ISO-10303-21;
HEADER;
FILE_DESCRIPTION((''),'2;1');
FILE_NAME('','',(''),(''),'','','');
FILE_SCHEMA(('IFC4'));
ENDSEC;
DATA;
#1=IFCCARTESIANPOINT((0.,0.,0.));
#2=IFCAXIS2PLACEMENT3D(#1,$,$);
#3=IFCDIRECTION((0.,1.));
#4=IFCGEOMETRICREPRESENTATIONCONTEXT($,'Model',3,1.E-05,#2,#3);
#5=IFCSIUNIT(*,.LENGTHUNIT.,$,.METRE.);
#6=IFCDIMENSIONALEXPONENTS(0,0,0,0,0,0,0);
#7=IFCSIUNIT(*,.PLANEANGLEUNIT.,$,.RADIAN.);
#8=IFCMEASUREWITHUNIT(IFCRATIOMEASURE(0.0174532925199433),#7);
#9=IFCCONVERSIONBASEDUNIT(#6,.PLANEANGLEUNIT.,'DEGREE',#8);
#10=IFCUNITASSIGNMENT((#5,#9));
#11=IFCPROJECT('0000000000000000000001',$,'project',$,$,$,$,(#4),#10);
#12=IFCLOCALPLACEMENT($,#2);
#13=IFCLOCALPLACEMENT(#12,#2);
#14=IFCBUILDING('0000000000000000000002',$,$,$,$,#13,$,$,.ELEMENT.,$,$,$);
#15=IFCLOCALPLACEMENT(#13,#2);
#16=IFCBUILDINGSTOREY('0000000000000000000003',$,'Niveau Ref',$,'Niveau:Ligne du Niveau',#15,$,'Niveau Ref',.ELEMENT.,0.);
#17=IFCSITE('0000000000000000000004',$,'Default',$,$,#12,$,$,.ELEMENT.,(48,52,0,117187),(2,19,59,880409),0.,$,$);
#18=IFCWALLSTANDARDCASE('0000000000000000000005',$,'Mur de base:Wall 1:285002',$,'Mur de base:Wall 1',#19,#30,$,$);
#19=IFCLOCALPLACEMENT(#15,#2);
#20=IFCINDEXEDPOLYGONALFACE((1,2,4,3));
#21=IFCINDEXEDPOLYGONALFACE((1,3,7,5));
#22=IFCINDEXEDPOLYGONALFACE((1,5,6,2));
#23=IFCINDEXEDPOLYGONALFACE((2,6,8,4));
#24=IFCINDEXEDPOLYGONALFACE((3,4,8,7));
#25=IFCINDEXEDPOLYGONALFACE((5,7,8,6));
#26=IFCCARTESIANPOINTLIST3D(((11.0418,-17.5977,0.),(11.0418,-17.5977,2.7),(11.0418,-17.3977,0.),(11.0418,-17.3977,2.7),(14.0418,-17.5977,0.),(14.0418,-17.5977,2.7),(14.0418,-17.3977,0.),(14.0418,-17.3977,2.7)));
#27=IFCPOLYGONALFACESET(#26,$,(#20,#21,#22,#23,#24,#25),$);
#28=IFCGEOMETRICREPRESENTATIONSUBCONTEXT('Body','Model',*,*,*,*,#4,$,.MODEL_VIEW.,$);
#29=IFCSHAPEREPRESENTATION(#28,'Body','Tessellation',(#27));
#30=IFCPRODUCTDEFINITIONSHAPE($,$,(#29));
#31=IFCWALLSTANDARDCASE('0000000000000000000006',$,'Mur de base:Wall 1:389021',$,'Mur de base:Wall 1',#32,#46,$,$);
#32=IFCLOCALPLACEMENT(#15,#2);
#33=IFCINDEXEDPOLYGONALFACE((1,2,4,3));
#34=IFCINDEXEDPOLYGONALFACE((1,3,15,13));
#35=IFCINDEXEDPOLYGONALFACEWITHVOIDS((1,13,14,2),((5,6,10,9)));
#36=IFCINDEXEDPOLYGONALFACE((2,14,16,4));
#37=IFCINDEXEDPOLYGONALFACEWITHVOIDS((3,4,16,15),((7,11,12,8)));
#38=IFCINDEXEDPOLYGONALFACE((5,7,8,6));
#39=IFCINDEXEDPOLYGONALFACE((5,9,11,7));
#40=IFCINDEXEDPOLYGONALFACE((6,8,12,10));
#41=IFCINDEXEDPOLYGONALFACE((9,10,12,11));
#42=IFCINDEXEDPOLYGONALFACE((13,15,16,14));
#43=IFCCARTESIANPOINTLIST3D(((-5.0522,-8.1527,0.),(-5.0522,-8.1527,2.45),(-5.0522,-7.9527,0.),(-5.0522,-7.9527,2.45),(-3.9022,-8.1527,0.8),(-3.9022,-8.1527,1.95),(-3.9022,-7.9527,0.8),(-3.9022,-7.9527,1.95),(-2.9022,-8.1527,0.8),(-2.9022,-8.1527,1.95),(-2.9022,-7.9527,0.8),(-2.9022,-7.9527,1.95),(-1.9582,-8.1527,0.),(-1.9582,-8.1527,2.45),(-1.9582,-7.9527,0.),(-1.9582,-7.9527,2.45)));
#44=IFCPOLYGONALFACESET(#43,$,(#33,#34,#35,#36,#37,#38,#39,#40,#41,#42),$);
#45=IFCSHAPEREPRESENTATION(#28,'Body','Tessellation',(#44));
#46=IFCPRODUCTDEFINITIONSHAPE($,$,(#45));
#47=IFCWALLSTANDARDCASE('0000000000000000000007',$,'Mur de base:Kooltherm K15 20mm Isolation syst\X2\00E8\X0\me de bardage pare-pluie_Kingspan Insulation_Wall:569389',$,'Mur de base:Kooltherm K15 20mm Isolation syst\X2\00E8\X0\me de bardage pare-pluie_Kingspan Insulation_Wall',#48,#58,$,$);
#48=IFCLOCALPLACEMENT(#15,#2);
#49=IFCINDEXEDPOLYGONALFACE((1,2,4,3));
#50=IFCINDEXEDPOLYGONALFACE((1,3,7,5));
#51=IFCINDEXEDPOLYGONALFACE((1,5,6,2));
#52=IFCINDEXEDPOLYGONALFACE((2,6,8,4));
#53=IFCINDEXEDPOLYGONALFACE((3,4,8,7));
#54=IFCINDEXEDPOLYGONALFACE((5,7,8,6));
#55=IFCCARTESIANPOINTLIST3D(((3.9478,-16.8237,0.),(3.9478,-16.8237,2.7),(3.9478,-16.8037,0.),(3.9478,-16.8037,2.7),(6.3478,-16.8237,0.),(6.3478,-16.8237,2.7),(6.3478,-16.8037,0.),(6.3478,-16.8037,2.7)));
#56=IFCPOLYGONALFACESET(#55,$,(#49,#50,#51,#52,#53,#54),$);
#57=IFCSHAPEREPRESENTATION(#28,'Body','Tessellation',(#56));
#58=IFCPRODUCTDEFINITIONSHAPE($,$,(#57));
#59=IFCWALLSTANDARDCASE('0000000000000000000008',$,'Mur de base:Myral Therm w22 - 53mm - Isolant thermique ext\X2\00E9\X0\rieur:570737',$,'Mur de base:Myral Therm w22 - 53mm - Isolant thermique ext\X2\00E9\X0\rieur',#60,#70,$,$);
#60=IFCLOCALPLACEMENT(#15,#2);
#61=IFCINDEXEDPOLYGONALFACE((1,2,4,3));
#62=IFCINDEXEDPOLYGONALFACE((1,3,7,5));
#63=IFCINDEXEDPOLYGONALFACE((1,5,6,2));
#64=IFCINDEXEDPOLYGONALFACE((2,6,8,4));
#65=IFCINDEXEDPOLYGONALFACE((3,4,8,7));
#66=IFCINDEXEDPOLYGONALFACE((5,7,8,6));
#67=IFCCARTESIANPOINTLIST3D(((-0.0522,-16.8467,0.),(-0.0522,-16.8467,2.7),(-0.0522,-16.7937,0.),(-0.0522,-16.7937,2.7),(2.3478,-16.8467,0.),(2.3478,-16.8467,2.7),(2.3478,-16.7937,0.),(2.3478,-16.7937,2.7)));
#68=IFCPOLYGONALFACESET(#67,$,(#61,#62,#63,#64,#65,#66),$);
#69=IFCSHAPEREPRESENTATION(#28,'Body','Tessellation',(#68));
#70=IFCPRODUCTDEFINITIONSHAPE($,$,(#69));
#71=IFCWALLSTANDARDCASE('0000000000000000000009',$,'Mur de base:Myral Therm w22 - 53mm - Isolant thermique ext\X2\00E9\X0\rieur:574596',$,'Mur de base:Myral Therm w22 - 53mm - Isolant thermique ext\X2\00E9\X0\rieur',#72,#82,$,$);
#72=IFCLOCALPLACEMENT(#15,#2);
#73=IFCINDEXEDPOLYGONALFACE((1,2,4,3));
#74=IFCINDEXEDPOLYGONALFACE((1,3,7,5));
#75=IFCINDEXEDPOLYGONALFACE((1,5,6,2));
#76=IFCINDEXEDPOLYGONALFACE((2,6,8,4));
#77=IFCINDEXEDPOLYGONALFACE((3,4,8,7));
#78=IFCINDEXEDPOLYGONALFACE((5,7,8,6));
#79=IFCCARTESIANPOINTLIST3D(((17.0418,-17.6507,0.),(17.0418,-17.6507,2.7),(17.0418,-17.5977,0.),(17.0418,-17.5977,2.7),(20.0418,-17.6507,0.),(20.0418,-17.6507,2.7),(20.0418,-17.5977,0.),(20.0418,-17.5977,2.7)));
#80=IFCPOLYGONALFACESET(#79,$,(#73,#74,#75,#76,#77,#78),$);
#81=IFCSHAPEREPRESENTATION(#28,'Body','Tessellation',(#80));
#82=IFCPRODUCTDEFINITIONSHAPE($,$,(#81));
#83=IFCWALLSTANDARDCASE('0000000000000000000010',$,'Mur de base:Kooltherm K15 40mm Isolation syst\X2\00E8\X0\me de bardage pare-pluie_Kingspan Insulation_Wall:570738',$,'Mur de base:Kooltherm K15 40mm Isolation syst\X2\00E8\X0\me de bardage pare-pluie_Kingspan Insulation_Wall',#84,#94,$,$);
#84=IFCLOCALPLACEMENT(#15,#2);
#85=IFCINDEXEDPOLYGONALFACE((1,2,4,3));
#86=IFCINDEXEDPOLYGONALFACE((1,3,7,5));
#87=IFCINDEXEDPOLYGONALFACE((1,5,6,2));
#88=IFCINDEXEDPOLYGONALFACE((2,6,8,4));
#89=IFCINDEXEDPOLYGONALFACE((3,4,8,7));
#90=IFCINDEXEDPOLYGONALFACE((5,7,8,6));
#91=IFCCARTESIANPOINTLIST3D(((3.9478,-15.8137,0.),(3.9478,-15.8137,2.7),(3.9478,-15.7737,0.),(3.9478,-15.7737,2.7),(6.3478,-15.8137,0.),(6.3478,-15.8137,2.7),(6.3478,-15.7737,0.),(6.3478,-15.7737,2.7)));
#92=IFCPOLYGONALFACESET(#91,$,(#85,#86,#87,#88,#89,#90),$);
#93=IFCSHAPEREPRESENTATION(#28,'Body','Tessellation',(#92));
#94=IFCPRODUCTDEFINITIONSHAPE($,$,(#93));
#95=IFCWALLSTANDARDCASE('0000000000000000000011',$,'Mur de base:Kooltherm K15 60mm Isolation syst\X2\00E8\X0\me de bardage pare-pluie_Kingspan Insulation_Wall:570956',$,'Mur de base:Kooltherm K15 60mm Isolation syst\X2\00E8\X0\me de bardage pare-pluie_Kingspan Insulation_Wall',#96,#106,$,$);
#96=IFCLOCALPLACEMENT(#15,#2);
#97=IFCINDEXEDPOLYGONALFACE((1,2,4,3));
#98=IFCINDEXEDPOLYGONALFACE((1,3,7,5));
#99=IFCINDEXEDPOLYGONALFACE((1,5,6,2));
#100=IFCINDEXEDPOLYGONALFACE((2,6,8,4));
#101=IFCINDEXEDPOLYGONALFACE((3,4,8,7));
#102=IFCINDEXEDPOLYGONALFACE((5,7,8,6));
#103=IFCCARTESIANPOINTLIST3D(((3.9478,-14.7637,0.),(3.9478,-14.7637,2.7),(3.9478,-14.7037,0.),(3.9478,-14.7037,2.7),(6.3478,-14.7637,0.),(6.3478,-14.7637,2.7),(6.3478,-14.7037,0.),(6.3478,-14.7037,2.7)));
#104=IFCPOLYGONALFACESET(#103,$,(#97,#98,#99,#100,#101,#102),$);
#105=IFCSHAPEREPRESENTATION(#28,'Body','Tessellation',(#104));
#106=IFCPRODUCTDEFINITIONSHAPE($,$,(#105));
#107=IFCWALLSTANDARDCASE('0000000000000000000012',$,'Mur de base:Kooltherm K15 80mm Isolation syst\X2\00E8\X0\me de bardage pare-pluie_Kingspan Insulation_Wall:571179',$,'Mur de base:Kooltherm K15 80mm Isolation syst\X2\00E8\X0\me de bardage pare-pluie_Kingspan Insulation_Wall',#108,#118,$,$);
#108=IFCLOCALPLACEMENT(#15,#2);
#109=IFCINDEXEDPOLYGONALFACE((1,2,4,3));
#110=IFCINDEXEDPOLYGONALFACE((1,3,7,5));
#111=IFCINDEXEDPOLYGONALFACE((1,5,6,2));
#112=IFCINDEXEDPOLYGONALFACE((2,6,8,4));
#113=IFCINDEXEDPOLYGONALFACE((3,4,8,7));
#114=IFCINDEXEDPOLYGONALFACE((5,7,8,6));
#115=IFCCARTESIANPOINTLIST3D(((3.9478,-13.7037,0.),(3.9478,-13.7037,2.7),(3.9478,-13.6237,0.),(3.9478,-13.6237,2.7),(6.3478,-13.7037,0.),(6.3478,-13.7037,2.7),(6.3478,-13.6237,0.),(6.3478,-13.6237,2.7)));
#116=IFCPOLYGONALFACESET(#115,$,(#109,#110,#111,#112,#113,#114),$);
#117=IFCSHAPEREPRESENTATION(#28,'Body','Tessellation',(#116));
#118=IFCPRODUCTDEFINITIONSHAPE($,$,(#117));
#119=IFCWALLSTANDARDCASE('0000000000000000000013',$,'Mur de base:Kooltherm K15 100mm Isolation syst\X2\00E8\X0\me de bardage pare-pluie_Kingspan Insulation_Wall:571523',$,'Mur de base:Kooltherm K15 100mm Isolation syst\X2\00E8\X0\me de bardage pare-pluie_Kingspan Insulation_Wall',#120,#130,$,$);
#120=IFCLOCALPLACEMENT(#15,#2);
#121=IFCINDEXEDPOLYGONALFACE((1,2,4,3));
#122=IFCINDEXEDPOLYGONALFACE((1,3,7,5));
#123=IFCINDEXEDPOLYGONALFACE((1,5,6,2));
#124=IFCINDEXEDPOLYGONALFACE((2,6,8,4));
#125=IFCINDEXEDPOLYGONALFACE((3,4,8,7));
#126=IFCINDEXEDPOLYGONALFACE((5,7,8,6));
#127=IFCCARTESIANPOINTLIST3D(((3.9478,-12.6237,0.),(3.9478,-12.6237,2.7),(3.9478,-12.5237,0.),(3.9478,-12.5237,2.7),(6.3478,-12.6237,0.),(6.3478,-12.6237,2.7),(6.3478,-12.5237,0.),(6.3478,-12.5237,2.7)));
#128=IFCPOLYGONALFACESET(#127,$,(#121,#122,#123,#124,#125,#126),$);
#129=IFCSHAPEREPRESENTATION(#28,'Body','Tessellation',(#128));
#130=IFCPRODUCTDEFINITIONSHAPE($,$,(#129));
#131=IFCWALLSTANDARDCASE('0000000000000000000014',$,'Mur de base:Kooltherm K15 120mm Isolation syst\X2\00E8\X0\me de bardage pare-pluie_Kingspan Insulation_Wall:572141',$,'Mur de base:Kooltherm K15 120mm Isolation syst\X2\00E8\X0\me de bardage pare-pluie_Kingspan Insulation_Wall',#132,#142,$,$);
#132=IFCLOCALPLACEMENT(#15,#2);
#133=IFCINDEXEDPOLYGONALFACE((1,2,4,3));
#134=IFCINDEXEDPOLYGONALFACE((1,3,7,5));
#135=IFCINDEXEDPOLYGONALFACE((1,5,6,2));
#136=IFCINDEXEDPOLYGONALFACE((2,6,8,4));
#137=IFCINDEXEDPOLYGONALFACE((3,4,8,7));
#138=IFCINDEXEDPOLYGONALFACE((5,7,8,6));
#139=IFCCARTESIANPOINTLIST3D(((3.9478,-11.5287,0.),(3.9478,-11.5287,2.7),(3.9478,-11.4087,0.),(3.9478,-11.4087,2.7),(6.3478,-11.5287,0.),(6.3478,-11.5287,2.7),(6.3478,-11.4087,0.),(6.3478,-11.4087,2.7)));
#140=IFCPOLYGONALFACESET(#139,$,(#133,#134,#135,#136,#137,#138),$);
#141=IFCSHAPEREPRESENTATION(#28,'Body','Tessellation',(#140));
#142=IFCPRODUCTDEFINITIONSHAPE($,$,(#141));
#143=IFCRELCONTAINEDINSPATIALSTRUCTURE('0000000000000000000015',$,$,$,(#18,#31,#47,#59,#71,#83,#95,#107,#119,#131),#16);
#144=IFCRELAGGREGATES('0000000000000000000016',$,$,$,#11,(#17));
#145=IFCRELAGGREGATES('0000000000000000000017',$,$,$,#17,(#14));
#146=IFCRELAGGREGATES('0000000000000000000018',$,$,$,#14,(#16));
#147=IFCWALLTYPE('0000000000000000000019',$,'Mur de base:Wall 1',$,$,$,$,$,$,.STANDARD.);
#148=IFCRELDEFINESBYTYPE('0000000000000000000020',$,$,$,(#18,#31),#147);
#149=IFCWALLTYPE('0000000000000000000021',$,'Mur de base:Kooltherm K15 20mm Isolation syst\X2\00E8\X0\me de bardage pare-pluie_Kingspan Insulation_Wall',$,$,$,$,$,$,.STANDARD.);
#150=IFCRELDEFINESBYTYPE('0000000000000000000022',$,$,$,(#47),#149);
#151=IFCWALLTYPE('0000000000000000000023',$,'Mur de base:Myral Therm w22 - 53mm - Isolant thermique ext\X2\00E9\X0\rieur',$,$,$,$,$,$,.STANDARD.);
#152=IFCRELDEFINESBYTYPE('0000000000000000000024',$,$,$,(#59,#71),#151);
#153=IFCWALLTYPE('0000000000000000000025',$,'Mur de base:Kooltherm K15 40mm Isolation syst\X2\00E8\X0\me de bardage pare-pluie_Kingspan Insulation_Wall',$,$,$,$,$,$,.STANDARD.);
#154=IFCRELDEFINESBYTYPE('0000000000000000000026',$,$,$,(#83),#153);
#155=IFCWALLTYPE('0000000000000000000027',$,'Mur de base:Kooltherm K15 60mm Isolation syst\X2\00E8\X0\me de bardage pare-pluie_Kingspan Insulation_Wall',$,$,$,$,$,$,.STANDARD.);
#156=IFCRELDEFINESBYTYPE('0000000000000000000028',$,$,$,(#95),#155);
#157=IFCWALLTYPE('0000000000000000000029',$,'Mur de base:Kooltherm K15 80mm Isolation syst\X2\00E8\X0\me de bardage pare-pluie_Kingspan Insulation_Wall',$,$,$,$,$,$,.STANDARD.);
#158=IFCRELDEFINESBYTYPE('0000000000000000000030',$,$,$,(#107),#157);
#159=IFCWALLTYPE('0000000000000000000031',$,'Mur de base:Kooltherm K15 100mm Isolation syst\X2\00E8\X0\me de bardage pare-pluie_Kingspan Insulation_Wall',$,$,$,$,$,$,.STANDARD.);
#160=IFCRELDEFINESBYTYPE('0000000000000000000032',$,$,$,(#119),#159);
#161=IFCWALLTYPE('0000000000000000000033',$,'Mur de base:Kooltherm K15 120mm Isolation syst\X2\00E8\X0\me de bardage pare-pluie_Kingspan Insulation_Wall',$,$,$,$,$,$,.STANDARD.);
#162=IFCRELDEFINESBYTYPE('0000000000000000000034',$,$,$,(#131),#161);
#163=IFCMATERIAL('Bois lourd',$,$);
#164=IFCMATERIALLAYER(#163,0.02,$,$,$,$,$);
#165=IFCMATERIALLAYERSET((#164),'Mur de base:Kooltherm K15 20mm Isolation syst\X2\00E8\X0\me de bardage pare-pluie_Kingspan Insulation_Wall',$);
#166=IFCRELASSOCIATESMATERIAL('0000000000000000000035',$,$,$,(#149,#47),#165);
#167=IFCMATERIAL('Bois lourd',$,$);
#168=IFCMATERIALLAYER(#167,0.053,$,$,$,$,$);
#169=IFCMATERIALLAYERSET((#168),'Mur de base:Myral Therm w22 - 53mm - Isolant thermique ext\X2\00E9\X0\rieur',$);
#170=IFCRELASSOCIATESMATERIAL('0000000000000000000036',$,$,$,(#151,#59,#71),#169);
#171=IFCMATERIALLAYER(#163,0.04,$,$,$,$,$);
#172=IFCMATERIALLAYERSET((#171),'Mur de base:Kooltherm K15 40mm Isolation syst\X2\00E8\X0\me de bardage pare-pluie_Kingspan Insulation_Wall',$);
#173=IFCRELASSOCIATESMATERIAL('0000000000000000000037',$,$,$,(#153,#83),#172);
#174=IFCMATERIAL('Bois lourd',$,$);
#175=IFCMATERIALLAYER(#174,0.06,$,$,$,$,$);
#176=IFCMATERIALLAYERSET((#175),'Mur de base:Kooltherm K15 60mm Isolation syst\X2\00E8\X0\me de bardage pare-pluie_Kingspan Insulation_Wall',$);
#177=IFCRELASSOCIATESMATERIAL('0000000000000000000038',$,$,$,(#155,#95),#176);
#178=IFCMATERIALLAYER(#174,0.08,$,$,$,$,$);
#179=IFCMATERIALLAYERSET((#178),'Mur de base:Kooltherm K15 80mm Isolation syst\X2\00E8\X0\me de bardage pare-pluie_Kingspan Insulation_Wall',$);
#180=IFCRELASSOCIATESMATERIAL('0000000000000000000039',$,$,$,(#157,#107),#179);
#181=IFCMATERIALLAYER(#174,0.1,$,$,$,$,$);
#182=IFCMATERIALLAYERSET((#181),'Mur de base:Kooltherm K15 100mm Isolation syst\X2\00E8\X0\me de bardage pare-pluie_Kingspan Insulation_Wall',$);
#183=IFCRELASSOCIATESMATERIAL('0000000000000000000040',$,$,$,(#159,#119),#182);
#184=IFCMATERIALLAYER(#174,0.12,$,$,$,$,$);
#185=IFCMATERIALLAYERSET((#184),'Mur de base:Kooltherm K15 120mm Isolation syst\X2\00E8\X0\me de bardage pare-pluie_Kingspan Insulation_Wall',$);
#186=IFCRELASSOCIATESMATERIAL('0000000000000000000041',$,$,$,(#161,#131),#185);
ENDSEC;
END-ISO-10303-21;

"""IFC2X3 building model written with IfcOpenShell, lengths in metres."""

from ifc_helpers import new_model, entity, si_unit, converted_unit, direction, frame, frame_2d, origin, place, context, subcontext, project, spatial, rectangle, extrude, material, layer, layer_set, layer_usage, type_object, element, save


model = new_model("IFC2X3")

# Units and contexts
model_context = context("Model", 3, precision=1e-05, world=origin(), true_north=direction((0.0, 1.0)))
body_context = subcontext(model_context, "Body", "Model", "MODEL_VIEW")
ifc_project = project(units=[si_unit("LENGTHUNIT", "METRE"), converted_unit("PLANEANGLEUNIT", "DEGREE", entity("IfcRatioMeasure", 0.0174532925199433), si_unit("PLANEANGLEUNIT", "RADIAN"), dimensions=[0, 0, 0, 0, 0, 0, 0])], contexts=[model_context])

# Site, building, storey
site_placement = place(None, origin())
site = spatial("IfcSite", under=ifc_project, at=site_placement, Name="Default", CompositionType="ELEMENT", RefLatitude=(48, 52, 0, 117187), RefLongitude=(2, 19, 59, 880409), RefElevation=0.0)
building_placement = place(site_placement, origin())
building = spatial("IfcBuilding", under=site, at=building_placement, CompositionType="ELEMENT")
storey_placement = place(building_placement, origin())
storey = spatial("IfcBuildingStorey", under=building, at=storey_placement, Name="Niveau Ref", ObjectType="Niveau:Ligne du Niveau", LongName="Niveau Ref", CompositionType="ELEMENT", Elevation=0.0)

# Wall
wall_type_1 = type_object("IfcWallType", Name="Mur de base:Wall 1", PredefinedType="STANDARD")
for number, where, name in (
    (1, (11.0418, -17.4977, 0.0), "Mur de base:Wall 1:285002"),
):
    element("IfcWallStandardCase", number, at=place(storey_placement, frame(where)), inside=storey, type_object=wall_type_1, Name=name, ObjectType="Mur de base:Wall 1", context=body_context, shape_type="SweptSolid", body=[
        extrude(rectangle(XDim=3.0, YDim=0.2, at=frame_2d((1.5, 0.0), x_axis=(-1.0, 0.0))), origin(), (0.0, 0.0, 1.0), 2.7),
    ])

# Wall, opening
wall_1_placement = place(storey_placement, frame((-1.9582, -8.0527, 0.0), z_axis=(0.0, 0.0, 1.0), x_axis=(-1.0, 0.0, 0.0)))
wall_1 = element("IfcWallStandardCase", 2, at=wall_1_placement, inside=storey, type_object=wall_type_1, Name="Mur de base:Wall 1:389021", ObjectType="Mur de base:Wall 1", context=body_context, shape_type="SweptSolid", body=[
    extrude(rectangle(XDim=3.094, YDim=0.2, at=frame_2d((1.547, 0.0), x_axis=(-1.0, 0.0))), origin(), (0.0, 0.0, 1.0), 2.45),
])
opening_placement = place(wall_1_placement, frame((0.944, -0.1, 0.8)))
element("IfcOpeningElement", 3, at=opening_placement, cuts=wall_1, ObjectType="Opening", context=body_context, shape_type="SweptSolid", body=[
    extrude(rectangle(XDim=1.15, YDim=1.0, at=frame_2d((0.575, 0.5), x_axis=(1.0, 0.0))), frame((0.0, 0.0, 0.0), z_axis=(0.0, 1.0, 0.0), x_axis=(0.0, 0.0, 1.0)), (0.0, 0.0, 1.0), 0.2),
])

# Walls
ifc_material_1 = material(Name="Bois lourd")
ifc_layer_1 = layer(ifc_material_1, 0.02)
ifc_layer_set_1 = layer_set([ifc_layer_1], Name="Mur de base:Kooltherm K15 20mm Isolation système de bardage pare-pluie_Kingspan Insulation_Wall")
ifc_layer_usage_1 = layer_usage(ifc_layer_set_1, "AXIS2", "NEGATIVE", 0.01)
wall_type_2 = type_object("IfcWallType", Name="Mur de base:Kooltherm K15 20mm Isolation système de bardage pare-pluie_Kingspan Insulation_Wall", PredefinedType="STANDARD", material=ifc_layer_set_1)
wall_2_placement = place(storey_placement, frame((3.9478, -16.8137, 0.0)))
element("IfcWallStandardCase", 4, at=wall_2_placement, inside=storey, type_object=wall_type_2, material=ifc_layer_usage_1, Name="Mur de base:Kooltherm K15 20mm Isolation système de bardage pare-pluie_Kingspan Insulation_Wall:569389", ObjectType="Mur de base:Kooltherm K15 20mm Isolation système de bardage pare-pluie_Kingspan Insulation_Wall", context=body_context, shape_type="SweptSolid", body=[
    extrude(rectangle(XDim=2.4, YDim=0.02, at=frame_2d((1.2, 0.0), x_axis=(-1.0, 0.0))), origin(), (0.0, 0.0, 1.0), 2.7),
])
ifc_material_2 = material(Name="Bois lourd")
ifc_layer_2 = layer(ifc_material_2, 0.053)
ifc_layer_set_2 = layer_set([ifc_layer_2], Name="Mur de base:Myral Therm w22 - 53mm - Isolant thermique extérieur")
ifc_layer_usage_2 = layer_usage(ifc_layer_set_2, "AXIS2", "NEGATIVE", 0.0265)
wall_type_3 = type_object("IfcWallType", Name="Mur de base:Myral Therm w22 - 53mm - Isolant thermique extérieur", PredefinedType="STANDARD", material=ifc_layer_set_2)
wall_3_placement = place(storey_placement, frame((-0.0522, -16.8202, 0.0)))
element("IfcWallStandardCase", 5, at=wall_3_placement, inside=storey, type_object=wall_type_3, material=ifc_layer_usage_2, Name="Mur de base:Myral Therm w22 - 53mm - Isolant thermique extérieur:570737", ObjectType="Mur de base:Myral Therm w22 - 53mm - Isolant thermique extérieur", context=body_context, shape_type="SweptSolid", body=[
    extrude(rectangle(XDim=2.4, YDim=0.053, at=frame_2d((1.2, 0.0), x_axis=(-1.0, 0.0))), origin(), (0.0, 0.0, 1.0), 2.7),
])
ifc_layer_usage_3 = layer_usage(ifc_layer_set_2, "AXIS2", "NEGATIVE", 0.0265)
wall_4_placement = place(storey_placement, frame((17.0418, -17.6242, 0.0)))
element("IfcWallStandardCase", 6, at=wall_4_placement, inside=storey, type_object=wall_type_3, material=ifc_layer_usage_3, Name="Mur de base:Myral Therm w22 - 53mm - Isolant thermique extérieur:574596", ObjectType="Mur de base:Myral Therm w22 - 53mm - Isolant thermique extérieur", context=body_context, shape_type="SweptSolid", body=[
    extrude(rectangle(XDim=3.0, YDim=0.053, at=frame_2d((1.5, 0.0), x_axis=(-1.0, 0.0))), origin(), (0.0, 0.0, 1.0), 2.7),
])
ifc_layer_3 = layer(ifc_material_1, 0.04)
ifc_layer_set_3 = layer_set([ifc_layer_3], Name="Mur de base:Kooltherm K15 40mm Isolation système de bardage pare-pluie_Kingspan Insulation_Wall")
ifc_layer_usage_4 = layer_usage(ifc_layer_set_3, "AXIS2", "NEGATIVE", 0.02)
wall_type_4 = type_object("IfcWallType", Name="Mur de base:Kooltherm K15 40mm Isolation système de bardage pare-pluie_Kingspan Insulation_Wall", PredefinedType="STANDARD", material=ifc_layer_set_3)
wall_5_placement = place(storey_placement, frame((3.9478, -15.7937, 0.0)))
element("IfcWallStandardCase", 7, at=wall_5_placement, inside=storey, type_object=wall_type_4, material=ifc_layer_usage_4, Name="Mur de base:Kooltherm K15 40mm Isolation système de bardage pare-pluie_Kingspan Insulation_Wall:570738", ObjectType="Mur de base:Kooltherm K15 40mm Isolation système de bardage pare-pluie_Kingspan Insulation_Wall", context=body_context, shape_type="SweptSolid", body=[
    extrude(rectangle(XDim=2.4, YDim=0.04, at=frame_2d((1.2, 0.0), x_axis=(-1.0, 0.0))), origin(), (0.0, 0.0, 1.0), 2.7),
])
ifc_material_3 = material(Name="Bois lourd")
ifc_layer_4 = layer(ifc_material_3, 0.06)
ifc_layer_set_4 = layer_set([ifc_layer_4], Name="Mur de base:Kooltherm K15 60mm Isolation système de bardage pare-pluie_Kingspan Insulation_Wall")
ifc_layer_usage_5 = layer_usage(ifc_layer_set_4, "AXIS2", "NEGATIVE", 0.03)
wall_type_5 = type_object("IfcWallType", Name="Mur de base:Kooltherm K15 60mm Isolation système de bardage pare-pluie_Kingspan Insulation_Wall", PredefinedType="STANDARD", material=ifc_layer_set_4)
wall_6_placement = place(storey_placement, frame((3.9478, -14.7337, 0.0)))
element("IfcWallStandardCase", 8, at=wall_6_placement, inside=storey, type_object=wall_type_5, material=ifc_layer_usage_5, Name="Mur de base:Kooltherm K15 60mm Isolation système de bardage pare-pluie_Kingspan Insulation_Wall:570956", ObjectType="Mur de base:Kooltherm K15 60mm Isolation système de bardage pare-pluie_Kingspan Insulation_Wall", context=body_context, shape_type="SweptSolid", body=[
    extrude(rectangle(XDim=2.4, YDim=0.06, at=frame_2d((1.2, 0.0), x_axis=(-1.0, 0.0))), origin(), (0.0, 0.0, 1.0), 2.7),
])
ifc_layer_5 = layer(ifc_material_3, 0.08)
ifc_layer_set_5 = layer_set([ifc_layer_5], Name="Mur de base:Kooltherm K15 80mm Isolation système de bardage pare-pluie_Kingspan Insulation_Wall")
ifc_layer_usage_6 = layer_usage(ifc_layer_set_5, "AXIS2", "NEGATIVE", 0.04)
wall_type_6 = type_object("IfcWallType", Name="Mur de base:Kooltherm K15 80mm Isolation système de bardage pare-pluie_Kingspan Insulation_Wall", PredefinedType="STANDARD", material=ifc_layer_set_5)
wall_7_placement = place(storey_placement, frame((3.9478, -13.6637, 0.0)))
element("IfcWallStandardCase", 9, at=wall_7_placement, inside=storey, type_object=wall_type_6, material=ifc_layer_usage_6, Name="Mur de base:Kooltherm K15 80mm Isolation système de bardage pare-pluie_Kingspan Insulation_Wall:571179", ObjectType="Mur de base:Kooltherm K15 80mm Isolation système de bardage pare-pluie_Kingspan Insulation_Wall", context=body_context, shape_type="SweptSolid", body=[
    extrude(rectangle(XDim=2.4, YDim=0.08, at=frame_2d((1.2, 0.0), x_axis=(-1.0, 0.0))), origin(), (0.0, 0.0, 1.0), 2.7),
])
ifc_layer_6 = layer(ifc_material_3, 0.1)
ifc_layer_set_6 = layer_set([ifc_layer_6], Name="Mur de base:Kooltherm K15 100mm Isolation système de bardage pare-pluie_Kingspan Insulation_Wall")
ifc_layer_usage_7 = layer_usage(ifc_layer_set_6, "AXIS2", "NEGATIVE", 0.05)
wall_type_7 = type_object("IfcWallType", Name="Mur de base:Kooltherm K15 100mm Isolation système de bardage pare-pluie_Kingspan Insulation_Wall", PredefinedType="STANDARD", material=ifc_layer_set_6)
wall_8_placement = place(storey_placement, frame((3.9478, -12.5737, 0.0)))
element("IfcWallStandardCase", 10, at=wall_8_placement, inside=storey, type_object=wall_type_7, material=ifc_layer_usage_7, Name="Mur de base:Kooltherm K15 100mm Isolation système de bardage pare-pluie_Kingspan Insulation_Wall:571523", ObjectType="Mur de base:Kooltherm K15 100mm Isolation système de bardage pare-pluie_Kingspan Insulation_Wall", context=body_context, shape_type="SweptSolid", body=[
    extrude(rectangle(XDim=2.4, YDim=0.1, at=frame_2d((1.2, 0.0), x_axis=(-1.0, 0.0))), origin(), (0.0, 0.0, 1.0), 2.7),
])
ifc_layer_7 = layer(ifc_material_3, 0.12)
ifc_layer_set_7 = layer_set([ifc_layer_7], Name="Mur de base:Kooltherm K15 120mm Isolation système de bardage pare-pluie_Kingspan Insulation_Wall")
ifc_layer_usage_8 = layer_usage(ifc_layer_set_7, "AXIS2", "NEGATIVE", 0.06)
wall_type_8 = type_object("IfcWallType", Name="Mur de base:Kooltherm K15 120mm Isolation système de bardage pare-pluie_Kingspan Insulation_Wall", PredefinedType="STANDARD", material=ifc_layer_set_7)
wall_9_placement = place(storey_placement, frame((3.9478, -11.4687, 0.0)))
element("IfcWallStandardCase", 11, at=wall_9_placement, inside=storey, type_object=wall_type_8, material=ifc_layer_usage_8, Name="Mur de base:Kooltherm K15 120mm Isolation système de bardage pare-pluie_Kingspan Insulation_Wall:572141", ObjectType="Mur de base:Kooltherm K15 120mm Isolation système de bardage pare-pluie_Kingspan Insulation_Wall", context=body_context, shape_type="SweptSolid", body=[
    extrude(rectangle(XDim=2.4, YDim=0.12, at=frame_2d((1.2, 0.0), x_axis=(-1.0, 0.0))), origin(), (0.0, 0.0, 1.0), 2.7),
])

save(model, "model.ifc")
